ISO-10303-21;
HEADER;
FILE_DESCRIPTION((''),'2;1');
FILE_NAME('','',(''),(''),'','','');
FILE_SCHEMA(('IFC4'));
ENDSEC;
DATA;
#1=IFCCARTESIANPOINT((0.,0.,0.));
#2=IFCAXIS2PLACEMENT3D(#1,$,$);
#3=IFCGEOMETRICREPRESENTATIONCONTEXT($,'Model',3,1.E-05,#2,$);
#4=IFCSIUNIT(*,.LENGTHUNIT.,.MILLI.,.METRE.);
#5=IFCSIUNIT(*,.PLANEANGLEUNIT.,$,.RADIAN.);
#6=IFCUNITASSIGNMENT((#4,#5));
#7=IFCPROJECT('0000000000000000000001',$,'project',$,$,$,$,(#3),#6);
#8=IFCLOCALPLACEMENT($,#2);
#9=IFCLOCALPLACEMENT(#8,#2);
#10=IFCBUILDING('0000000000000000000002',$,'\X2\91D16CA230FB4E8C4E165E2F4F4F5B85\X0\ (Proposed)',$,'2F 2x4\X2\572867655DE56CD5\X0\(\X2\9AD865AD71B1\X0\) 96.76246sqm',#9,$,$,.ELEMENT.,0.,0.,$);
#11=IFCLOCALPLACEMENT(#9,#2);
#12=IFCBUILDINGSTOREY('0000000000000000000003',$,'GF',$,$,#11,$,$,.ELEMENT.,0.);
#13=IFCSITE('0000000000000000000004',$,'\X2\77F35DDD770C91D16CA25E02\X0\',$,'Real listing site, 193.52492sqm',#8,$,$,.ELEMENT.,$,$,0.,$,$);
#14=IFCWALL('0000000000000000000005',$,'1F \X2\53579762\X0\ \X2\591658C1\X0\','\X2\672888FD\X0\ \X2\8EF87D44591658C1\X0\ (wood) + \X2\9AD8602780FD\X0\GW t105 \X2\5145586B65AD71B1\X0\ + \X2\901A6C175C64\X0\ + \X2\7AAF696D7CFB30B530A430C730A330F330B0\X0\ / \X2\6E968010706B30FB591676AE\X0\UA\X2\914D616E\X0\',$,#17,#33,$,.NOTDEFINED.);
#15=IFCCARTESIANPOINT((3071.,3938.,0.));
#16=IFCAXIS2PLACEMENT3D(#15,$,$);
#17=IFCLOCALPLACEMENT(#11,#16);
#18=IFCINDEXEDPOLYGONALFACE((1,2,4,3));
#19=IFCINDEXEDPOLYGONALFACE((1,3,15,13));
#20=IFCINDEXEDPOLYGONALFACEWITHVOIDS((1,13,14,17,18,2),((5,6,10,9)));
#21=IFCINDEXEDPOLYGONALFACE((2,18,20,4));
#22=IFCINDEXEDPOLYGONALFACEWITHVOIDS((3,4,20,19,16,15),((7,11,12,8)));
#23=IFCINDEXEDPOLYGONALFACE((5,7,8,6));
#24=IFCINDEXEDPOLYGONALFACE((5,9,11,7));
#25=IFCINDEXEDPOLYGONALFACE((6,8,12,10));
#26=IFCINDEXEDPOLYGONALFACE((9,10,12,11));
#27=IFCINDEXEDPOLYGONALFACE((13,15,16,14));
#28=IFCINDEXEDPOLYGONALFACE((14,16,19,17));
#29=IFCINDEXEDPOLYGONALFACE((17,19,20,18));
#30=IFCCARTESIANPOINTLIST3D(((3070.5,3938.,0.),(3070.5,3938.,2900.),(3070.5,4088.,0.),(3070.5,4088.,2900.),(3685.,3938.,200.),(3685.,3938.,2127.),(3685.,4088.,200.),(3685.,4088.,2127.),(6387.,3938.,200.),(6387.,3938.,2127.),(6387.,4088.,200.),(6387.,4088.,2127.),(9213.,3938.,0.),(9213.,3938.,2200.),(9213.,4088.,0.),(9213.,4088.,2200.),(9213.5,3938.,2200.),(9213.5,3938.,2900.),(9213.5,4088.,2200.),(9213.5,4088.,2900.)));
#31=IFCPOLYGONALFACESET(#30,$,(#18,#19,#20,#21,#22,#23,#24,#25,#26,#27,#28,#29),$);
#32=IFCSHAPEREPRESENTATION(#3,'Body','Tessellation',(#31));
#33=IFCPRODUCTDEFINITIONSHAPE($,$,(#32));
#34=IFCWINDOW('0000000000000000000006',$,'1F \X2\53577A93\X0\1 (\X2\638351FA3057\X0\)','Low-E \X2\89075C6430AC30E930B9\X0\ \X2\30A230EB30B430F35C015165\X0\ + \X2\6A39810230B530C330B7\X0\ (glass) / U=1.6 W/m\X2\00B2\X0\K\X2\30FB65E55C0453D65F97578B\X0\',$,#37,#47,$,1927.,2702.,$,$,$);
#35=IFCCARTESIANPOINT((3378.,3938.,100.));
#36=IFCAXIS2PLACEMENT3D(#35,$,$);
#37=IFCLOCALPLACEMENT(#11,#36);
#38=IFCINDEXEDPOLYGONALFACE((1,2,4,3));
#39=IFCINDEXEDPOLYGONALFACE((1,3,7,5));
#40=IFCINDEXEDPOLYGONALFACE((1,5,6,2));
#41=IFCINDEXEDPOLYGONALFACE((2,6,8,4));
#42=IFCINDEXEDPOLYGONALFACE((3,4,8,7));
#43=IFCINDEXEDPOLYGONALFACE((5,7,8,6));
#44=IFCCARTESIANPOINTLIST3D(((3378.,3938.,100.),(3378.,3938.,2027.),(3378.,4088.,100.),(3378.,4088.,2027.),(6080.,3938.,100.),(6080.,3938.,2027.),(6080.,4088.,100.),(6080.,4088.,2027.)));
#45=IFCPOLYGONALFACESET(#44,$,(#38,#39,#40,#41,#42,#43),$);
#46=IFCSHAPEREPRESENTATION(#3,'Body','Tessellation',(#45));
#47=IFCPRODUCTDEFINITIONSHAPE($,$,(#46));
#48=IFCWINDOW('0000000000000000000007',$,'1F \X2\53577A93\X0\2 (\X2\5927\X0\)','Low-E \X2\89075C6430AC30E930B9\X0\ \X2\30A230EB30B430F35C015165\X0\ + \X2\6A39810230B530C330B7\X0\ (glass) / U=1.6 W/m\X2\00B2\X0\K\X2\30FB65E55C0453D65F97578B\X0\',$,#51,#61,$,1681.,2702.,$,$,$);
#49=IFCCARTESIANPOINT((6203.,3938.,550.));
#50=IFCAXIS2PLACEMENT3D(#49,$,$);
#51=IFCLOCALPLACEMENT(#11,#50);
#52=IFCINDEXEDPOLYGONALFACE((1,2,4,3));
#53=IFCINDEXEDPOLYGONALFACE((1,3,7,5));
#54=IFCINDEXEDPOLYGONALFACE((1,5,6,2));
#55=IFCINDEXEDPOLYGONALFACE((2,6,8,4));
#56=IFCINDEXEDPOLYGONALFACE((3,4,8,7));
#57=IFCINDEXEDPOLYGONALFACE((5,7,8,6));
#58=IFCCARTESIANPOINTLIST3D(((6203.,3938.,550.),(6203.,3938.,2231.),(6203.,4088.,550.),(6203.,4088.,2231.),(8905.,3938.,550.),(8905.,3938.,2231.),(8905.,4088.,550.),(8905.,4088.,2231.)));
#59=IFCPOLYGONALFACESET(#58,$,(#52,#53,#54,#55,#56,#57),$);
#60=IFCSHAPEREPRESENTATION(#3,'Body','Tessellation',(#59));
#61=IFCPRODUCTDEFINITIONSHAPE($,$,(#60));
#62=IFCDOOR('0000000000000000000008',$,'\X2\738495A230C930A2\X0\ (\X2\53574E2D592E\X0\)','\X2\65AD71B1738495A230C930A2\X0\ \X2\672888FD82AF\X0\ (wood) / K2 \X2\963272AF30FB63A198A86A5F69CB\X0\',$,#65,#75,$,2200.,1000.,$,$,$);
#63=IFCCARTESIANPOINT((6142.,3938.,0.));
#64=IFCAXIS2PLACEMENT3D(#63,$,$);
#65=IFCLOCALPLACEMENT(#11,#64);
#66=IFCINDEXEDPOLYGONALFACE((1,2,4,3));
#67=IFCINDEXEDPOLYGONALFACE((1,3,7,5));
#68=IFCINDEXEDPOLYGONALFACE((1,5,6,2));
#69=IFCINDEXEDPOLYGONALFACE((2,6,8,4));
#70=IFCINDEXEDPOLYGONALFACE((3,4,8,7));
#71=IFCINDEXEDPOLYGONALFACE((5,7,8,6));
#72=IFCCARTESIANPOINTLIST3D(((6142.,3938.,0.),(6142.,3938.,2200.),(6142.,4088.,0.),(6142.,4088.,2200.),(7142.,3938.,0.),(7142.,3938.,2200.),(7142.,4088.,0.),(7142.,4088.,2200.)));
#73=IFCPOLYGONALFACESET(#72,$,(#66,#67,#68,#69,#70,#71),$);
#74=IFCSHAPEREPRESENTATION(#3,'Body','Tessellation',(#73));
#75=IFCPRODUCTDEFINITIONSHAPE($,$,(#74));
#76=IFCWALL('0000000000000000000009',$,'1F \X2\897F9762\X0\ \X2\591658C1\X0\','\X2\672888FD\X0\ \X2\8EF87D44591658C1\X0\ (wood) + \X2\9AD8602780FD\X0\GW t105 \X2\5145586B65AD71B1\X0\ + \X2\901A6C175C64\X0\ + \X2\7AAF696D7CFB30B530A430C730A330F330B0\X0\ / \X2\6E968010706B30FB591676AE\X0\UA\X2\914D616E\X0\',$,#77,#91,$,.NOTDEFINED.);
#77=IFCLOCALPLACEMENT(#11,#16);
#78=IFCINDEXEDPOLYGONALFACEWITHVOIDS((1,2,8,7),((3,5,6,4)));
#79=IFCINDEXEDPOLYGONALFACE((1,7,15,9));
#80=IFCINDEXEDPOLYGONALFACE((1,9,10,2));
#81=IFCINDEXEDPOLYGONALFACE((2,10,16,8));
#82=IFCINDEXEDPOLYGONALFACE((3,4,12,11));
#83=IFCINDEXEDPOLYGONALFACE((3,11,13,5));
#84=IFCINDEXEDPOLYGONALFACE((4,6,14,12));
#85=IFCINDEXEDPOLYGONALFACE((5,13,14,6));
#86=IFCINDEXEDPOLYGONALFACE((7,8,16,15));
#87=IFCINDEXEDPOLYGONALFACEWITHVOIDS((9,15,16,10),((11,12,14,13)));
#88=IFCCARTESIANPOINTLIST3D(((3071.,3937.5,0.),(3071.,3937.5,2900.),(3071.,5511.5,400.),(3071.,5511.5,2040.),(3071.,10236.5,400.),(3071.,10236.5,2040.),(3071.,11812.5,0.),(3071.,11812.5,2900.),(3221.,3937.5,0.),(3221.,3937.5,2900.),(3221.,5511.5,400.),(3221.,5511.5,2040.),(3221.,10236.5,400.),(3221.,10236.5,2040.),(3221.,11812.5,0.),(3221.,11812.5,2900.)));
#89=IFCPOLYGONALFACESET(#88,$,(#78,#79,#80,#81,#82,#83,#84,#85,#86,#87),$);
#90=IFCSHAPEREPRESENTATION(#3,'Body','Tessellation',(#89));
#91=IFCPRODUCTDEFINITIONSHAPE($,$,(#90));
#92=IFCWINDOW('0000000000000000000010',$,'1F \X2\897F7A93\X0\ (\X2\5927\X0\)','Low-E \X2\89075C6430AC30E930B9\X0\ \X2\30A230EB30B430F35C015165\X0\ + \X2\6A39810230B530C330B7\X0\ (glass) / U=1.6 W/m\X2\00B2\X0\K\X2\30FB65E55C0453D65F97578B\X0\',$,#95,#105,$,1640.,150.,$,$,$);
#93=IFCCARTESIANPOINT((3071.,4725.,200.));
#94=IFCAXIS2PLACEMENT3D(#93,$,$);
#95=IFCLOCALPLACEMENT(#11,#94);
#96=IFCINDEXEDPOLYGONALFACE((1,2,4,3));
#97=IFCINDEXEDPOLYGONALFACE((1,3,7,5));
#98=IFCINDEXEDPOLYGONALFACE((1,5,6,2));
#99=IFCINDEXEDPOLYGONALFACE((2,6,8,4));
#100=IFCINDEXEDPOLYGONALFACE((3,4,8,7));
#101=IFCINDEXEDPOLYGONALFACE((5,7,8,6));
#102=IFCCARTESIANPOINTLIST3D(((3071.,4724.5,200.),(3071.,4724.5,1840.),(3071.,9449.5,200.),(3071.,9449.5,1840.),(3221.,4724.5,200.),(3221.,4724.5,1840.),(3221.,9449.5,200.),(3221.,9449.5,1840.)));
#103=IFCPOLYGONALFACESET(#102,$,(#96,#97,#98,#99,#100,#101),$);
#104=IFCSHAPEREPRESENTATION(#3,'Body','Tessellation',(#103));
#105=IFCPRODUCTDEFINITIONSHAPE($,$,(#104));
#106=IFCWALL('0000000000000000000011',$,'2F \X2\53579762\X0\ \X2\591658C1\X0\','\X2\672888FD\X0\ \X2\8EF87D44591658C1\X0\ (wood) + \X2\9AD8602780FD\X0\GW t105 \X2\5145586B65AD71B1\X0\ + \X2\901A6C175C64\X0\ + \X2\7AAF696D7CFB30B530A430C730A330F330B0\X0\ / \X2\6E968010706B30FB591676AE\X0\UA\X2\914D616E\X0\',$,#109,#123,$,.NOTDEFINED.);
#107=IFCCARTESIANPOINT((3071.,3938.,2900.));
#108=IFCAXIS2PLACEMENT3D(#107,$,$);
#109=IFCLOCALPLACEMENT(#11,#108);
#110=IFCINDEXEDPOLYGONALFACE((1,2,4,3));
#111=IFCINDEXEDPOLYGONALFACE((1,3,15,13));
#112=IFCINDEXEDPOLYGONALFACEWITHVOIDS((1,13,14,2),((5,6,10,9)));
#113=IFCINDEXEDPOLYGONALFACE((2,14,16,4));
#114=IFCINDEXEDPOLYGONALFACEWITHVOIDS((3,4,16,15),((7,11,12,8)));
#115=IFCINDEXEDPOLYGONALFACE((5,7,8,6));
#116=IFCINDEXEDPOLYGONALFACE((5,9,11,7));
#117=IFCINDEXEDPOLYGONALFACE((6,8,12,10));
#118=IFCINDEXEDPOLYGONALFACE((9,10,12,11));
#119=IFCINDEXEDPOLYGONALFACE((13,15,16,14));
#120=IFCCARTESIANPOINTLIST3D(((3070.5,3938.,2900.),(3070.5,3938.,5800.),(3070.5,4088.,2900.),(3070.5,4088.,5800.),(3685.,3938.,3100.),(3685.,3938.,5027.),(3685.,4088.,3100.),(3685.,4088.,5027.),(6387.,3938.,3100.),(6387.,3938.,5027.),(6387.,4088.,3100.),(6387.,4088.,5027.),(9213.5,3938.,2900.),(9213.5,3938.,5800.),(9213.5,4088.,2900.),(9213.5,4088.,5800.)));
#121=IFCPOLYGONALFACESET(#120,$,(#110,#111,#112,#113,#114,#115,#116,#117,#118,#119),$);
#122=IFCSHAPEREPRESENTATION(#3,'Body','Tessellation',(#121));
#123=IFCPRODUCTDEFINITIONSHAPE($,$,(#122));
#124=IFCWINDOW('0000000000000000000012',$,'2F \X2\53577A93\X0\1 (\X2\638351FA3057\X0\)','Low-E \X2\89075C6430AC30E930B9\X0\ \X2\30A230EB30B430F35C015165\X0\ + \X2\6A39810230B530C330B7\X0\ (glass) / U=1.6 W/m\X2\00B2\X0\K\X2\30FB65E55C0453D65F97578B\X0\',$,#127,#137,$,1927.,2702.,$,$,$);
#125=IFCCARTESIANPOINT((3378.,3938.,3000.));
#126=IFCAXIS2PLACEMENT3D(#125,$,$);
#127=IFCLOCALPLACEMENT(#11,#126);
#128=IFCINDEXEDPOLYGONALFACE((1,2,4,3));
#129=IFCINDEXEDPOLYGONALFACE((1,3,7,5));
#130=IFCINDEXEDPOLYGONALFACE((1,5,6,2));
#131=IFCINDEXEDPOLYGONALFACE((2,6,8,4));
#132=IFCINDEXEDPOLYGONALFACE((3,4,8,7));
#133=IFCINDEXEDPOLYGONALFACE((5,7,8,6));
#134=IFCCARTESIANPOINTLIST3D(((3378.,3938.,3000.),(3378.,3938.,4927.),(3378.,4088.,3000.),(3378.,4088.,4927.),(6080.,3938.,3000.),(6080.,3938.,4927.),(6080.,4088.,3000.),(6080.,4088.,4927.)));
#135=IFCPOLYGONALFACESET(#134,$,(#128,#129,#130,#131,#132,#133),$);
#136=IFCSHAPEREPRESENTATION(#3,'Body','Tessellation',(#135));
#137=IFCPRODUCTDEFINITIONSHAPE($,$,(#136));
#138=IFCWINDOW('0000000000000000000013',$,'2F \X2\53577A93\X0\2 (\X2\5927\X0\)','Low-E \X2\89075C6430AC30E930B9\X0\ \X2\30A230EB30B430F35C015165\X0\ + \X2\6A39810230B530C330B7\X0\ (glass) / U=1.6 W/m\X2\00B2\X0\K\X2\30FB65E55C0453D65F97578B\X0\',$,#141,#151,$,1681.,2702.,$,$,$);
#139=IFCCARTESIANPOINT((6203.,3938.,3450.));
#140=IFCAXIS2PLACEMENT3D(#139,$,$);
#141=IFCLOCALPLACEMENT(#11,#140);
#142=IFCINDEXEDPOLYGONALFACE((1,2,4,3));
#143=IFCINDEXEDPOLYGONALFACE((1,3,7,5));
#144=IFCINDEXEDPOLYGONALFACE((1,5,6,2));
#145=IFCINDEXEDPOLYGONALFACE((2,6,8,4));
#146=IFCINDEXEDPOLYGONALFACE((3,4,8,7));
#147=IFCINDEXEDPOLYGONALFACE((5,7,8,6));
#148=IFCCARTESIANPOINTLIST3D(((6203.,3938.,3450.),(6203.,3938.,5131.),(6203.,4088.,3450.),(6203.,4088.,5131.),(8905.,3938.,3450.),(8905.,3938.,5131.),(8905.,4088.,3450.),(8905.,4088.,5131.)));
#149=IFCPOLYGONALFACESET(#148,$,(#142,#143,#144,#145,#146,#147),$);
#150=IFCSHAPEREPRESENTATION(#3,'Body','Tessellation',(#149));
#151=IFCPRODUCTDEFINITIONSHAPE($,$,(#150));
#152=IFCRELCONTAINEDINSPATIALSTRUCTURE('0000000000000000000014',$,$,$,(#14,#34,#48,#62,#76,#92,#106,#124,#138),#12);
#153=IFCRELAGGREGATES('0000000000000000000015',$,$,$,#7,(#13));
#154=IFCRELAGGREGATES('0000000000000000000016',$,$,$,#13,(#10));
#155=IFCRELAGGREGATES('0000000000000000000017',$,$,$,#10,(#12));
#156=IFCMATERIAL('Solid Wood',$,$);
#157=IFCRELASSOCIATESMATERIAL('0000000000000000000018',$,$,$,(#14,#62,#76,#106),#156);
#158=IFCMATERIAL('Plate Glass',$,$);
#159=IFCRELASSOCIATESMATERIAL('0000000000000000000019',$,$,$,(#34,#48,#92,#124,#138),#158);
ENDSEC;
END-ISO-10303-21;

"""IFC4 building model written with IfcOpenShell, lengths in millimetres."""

from ifc_helpers import new_model, si_unit, frame, frame_2d, origin, place, context, project, spatial, rectangle, extrude, material, element, fill, save


model = new_model("IFC4")

# Units and contexts
model_context = context("Model", 3, precision=1e-05, world=origin())
ifc_project = project(units=[si_unit("LENGTHUNIT", "METRE", prefix="MILLI"), si_unit("PLANEANGLEUNIT", "RADIAN")], contexts=[model_context])

# Site, building, storey
site_placement = place(None, origin())
site = spatial("IfcSite", under=ifc_project, at=site_placement, Name="石川県金沢市", ObjectType="Real listing site, 193.52492sqm", CompositionType="ELEMENT", RefElevation=0.0)
building_placement = place(site_placement, origin())
building = spatial("IfcBuilding", under=site, at=building_placement, Name="金沢・二世帯住宅 (Proposed)", ObjectType="2F 2x4在来工法(高断熱) 96.76246sqm", CompositionType="ELEMENT", ElevationOfRefHeight=0.0, ElevationOfTerrain=0.0)
storey_placement = place(building_placement, origin())
storey = spatial("IfcBuildingStorey", under=building, at=storey_placement, Name="GF", CompositionType="ELEMENT", Elevation=0.0)

# Shared definitions
ifc_material_1 = material(Name="Solid Wood")

# Wall, openings, windows, door
wall_1_placement = place(storey_placement, frame((3071.0, 3938.0, 0.0)))
wall_1 = element("IfcWall", 1, at=wall_1_placement, inside=storey, material=ifc_material_1, Name="1F 南面 外壁", Description="木製 軸組外壁 (wood) + 高性能GW t105 充填断熱 + 通気層 + 窯業系サイディング / 準耐火・外皮UA配慮", PredefinedType="NOTDEFINED", context=model_context, shape_type="SweptSolid", body=[
    extrude(rectangle(XDim=6143.0, YDim=150.0, at=frame_2d((3071.0, 75.0))), frame((3071.0, 3938.0, 0.0)), (0.0, 0.0, 1.0), 2900.0),
])
opening_1_placement = place(storey_placement, frame((3378.0, 3938.0, 100.0)))
opening_1 = element("IfcOpeningElement", 2, at=opening_1_placement, cuts=wall_1, PredefinedType="NOTDEFINED", context=model_context, shape_type="SweptSolid", body=[
    extrude(rectangle(XDim=2702.0, YDim=150.0, at=frame_2d((1351.0, 75.0))), frame((3378.0, 3938.0, 100.0)), (0.0, 0.0, 1.0), 1927.0),
])
opening_2_placement = place(storey_placement, frame((6203.0, 3938.0, 550.0)))
opening_2 = element("IfcOpeningElement", 3, at=opening_2_placement, cuts=wall_1, PredefinedType="NOTDEFINED", context=model_context, shape_type="SweptSolid", body=[
    extrude(rectangle(XDim=2702.0, YDim=150.0, at=frame_2d((1351.0, 75.0))), frame((6203.0, 3938.0, 550.0)), (0.0, 0.0, 1.0), 1681.0),
])
opening_3_placement = place(storey_placement, frame((6142.0, 3938.0, 0.0)))
opening_3 = element("IfcOpeningElement", 4, at=opening_3_placement, cuts=wall_1, PredefinedType="NOTDEFINED", context=model_context, shape_type="SweptSolid", body=[
    extrude(rectangle(XDim=1000.0, YDim=150.0, at=frame_2d((500.0, 75.0))), frame((6142.0, 3938.0, 0.0)), (0.0, 0.0, 1.0), 2200.0),
])
ifc_material_2 = material(Name="Plate Glass")
window_1_placement = place(storey_placement, frame((3378.0, 3938.0, 100.0)))
window_1 = element("IfcWindow", 5, at=window_1_placement, inside=storey, material=ifc_material_2, Name="1F 南窓1 (掃出し)", Description="Low-E 複層ガラス アルゴン封入 + 樹脂サッシ (glass) / U=1.6 W/m²K・日射取得型", OverallHeight=1927.0, OverallWidth=2702.0, context=model_context, shape_type="SweptSolid", body=[
    extrude(rectangle(XDim=2702.0, YDim=150.0, at=frame_2d((1351.0, 75.0))), frame((3378.0, 3938.0, 100.0)), (0.0, 0.0, 1.0), 1927.0),
])
fill(opening_1, window_1)
window_2_placement = place(storey_placement, frame((6203.0, 3938.0, 550.0)))
window_2 = element("IfcWindow", 6, at=window_2_placement, inside=storey, material=ifc_material_2, Name="1F 南窓2 (大)", Description="Low-E 複層ガラス アルゴン封入 + 樹脂サッシ (glass) / U=1.6 W/m²K・日射取得型", OverallHeight=1681.0, OverallWidth=2702.0, context=model_context, shape_type="SweptSolid", body=[
    extrude(rectangle(XDim=2702.0, YDim=150.0, at=frame_2d((1351.0, 75.0))), frame((6203.0, 3938.0, 550.0)), (0.0, 0.0, 1.0), 1681.0),
])
fill(opening_2, window_2)
door_placement = place(storey_placement, frame((6142.0, 3938.0, 0.0)))
door = element("IfcDoor", 7, at=door_placement, inside=storey, material=ifc_material_1, Name="玄関ドア (南中央)", Description="断熱玄関ドア 木製芯 (wood) / K2 防犯・採風機構", OverallHeight=2200.0, OverallWidth=1000.0, context=model_context, shape_type="SweptSolid", body=[
    extrude(rectangle(XDim=1000.0, YDim=150.0, at=frame_2d((500.0, 75.0))), frame((6142.0, 3938.0, 0.0)), (0.0, 0.0, 1.0), 2200.0),
])
fill(opening_3, door)

# Wall, opening, window
wall_2_placement = place(storey_placement, frame((3071.0, 3938.0, 0.0)))
wall_2 = element("IfcWall", 8, at=wall_2_placement, inside=storey, material=ifc_material_1, Name="1F 西面 外壁", Description="木製 軸組外壁 (wood) + 高性能GW t105 充填断熱 + 通気層 + 窯業系サイディング / 準耐火・外皮UA配慮", PredefinedType="NOTDEFINED", context=model_context, shape_type="SweptSolid", body=[
    extrude(rectangle(XDim=150.0, YDim=7875.0, at=frame_2d((75.0, 3937.0))), frame((3071.0, 3938.0, 0.0)), (0.0, 0.0, 1.0), 2900.0),
])
opening_4_placement = place(storey_placement, frame((3071.0, 4725.0, 200.0)))
opening_4 = element("IfcOpeningElement", 9, at=opening_4_placement, cuts=wall_2, PredefinedType="NOTDEFINED", context=model_context, shape_type="SweptSolid", body=[
    extrude(rectangle(XDim=150.0, YDim=4725.0, at=frame_2d((75.0, 2362.0))), frame((3071.0, 4725.0, 200.0)), (0.0, 0.0, 1.0), 1640.0),
])
window_3_placement = place(storey_placement, frame((3071.0, 4725.0, 200.0)))
window_3 = element("IfcWindow", 10, at=window_3_placement, inside=storey, material=ifc_material_2, Name="1F 西窓 (大)", Description="Low-E 複層ガラス アルゴン封入 + 樹脂サッシ (glass) / U=1.6 W/m²K・日射取得型", OverallHeight=1640.0, OverallWidth=150.0, context=model_context, shape_type="SweptSolid", body=[
    extrude(rectangle(XDim=150.0, YDim=4725.0, at=frame_2d((75.0, 2362.0))), frame((3071.0, 4725.0, 200.0)), (0.0, 0.0, 1.0), 1640.0),
])
fill(opening_4, window_3)

# Wall, openings, windows
wall_3_placement = place(storey_placement, frame((3071.0, 3938.0, 2900.0)))
wall_3 = element("IfcWall", 11, at=wall_3_placement, inside=storey, material=ifc_material_1, Name="2F 南面 外壁", Description="木製 軸組外壁 (wood) + 高性能GW t105 充填断熱 + 通気層 + 窯業系サイディング / 準耐火・外皮UA配慮", PredefinedType="NOTDEFINED", context=model_context, shape_type="SweptSolid", body=[
    extrude(rectangle(XDim=6143.0, YDim=150.0, at=frame_2d((3071.0, 75.0))), frame((3071.0, 3938.0, 2900.0)), (0.0, 0.0, 1.0), 2900.0),
])
opening_5_placement = place(storey_placement, frame((3378.0, 3938.0, 3000.0)))
opening_5 = element("IfcOpeningElement", 12, at=opening_5_placement, cuts=wall_3, PredefinedType="NOTDEFINED", context=model_context, shape_type="SweptSolid", body=[
    extrude(rectangle(XDim=2702.0, YDim=150.0, at=frame_2d((1351.0, 75.0))), frame((3378.0, 3938.0, 3000.0)), (0.0, 0.0, 1.0), 1927.0),
])
opening_6_placement = place(storey_placement, frame((6203.0, 3938.0, 3450.0)))
opening_6 = element("IfcOpeningElement", 13, at=opening_6_placement, cuts=wall_3, PredefinedType="NOTDEFINED", context=model_context, shape_type="SweptSolid", body=[
    extrude(rectangle(XDim=2702.0, YDim=150.0, at=frame_2d((1351.0, 75.0))), frame((6203.0, 3938.0, 3450.0)), (0.0, 0.0, 1.0), 1681.0),
])
window_4_placement = place(storey_placement, frame((3378.0, 3938.0, 3000.0)))
window_4 = element("IfcWindow", 14, at=window_4_placement, inside=storey, material=ifc_material_2, Name="2F 南窓1 (掃出し)", Description="Low-E 複層ガラス アルゴン封入 + 樹脂サッシ (glass) / U=1.6 W/m²K・日射取得型", OverallHeight=1927.0, OverallWidth=2702.0, context=model_context, shape_type="SweptSolid", body=[
    extrude(rectangle(XDim=2702.0, YDim=150.0, at=frame_2d((1351.0, 75.0))), frame((3378.0, 3938.0, 3000.0)), (0.0, 0.0, 1.0), 1927.0),
])
fill(opening_5, window_4)
window_5_placement = place(storey_placement, frame((6203.0, 3938.0, 3450.0)))
window_5 = element("IfcWindow", 15, at=window_5_placement, inside=storey, material=ifc_material_2, Name="2F 南窓2 (大)", Description="Low-E 複層ガラス アルゴン封入 + 樹脂サッシ (glass) / U=1.6 W/m²K・日射取得型", OverallHeight=1681.0, OverallWidth=2702.0, context=model_context, shape_type="SweptSolid", body=[
    extrude(rectangle(XDim=2702.0, YDim=150.0, at=frame_2d((1351.0, 75.0))), frame((6203.0, 3938.0, 3450.0)), (0.0, 0.0, 1.0), 1681.0),
])
fill(opening_6, window_5)

save(model, "model.ifc")
